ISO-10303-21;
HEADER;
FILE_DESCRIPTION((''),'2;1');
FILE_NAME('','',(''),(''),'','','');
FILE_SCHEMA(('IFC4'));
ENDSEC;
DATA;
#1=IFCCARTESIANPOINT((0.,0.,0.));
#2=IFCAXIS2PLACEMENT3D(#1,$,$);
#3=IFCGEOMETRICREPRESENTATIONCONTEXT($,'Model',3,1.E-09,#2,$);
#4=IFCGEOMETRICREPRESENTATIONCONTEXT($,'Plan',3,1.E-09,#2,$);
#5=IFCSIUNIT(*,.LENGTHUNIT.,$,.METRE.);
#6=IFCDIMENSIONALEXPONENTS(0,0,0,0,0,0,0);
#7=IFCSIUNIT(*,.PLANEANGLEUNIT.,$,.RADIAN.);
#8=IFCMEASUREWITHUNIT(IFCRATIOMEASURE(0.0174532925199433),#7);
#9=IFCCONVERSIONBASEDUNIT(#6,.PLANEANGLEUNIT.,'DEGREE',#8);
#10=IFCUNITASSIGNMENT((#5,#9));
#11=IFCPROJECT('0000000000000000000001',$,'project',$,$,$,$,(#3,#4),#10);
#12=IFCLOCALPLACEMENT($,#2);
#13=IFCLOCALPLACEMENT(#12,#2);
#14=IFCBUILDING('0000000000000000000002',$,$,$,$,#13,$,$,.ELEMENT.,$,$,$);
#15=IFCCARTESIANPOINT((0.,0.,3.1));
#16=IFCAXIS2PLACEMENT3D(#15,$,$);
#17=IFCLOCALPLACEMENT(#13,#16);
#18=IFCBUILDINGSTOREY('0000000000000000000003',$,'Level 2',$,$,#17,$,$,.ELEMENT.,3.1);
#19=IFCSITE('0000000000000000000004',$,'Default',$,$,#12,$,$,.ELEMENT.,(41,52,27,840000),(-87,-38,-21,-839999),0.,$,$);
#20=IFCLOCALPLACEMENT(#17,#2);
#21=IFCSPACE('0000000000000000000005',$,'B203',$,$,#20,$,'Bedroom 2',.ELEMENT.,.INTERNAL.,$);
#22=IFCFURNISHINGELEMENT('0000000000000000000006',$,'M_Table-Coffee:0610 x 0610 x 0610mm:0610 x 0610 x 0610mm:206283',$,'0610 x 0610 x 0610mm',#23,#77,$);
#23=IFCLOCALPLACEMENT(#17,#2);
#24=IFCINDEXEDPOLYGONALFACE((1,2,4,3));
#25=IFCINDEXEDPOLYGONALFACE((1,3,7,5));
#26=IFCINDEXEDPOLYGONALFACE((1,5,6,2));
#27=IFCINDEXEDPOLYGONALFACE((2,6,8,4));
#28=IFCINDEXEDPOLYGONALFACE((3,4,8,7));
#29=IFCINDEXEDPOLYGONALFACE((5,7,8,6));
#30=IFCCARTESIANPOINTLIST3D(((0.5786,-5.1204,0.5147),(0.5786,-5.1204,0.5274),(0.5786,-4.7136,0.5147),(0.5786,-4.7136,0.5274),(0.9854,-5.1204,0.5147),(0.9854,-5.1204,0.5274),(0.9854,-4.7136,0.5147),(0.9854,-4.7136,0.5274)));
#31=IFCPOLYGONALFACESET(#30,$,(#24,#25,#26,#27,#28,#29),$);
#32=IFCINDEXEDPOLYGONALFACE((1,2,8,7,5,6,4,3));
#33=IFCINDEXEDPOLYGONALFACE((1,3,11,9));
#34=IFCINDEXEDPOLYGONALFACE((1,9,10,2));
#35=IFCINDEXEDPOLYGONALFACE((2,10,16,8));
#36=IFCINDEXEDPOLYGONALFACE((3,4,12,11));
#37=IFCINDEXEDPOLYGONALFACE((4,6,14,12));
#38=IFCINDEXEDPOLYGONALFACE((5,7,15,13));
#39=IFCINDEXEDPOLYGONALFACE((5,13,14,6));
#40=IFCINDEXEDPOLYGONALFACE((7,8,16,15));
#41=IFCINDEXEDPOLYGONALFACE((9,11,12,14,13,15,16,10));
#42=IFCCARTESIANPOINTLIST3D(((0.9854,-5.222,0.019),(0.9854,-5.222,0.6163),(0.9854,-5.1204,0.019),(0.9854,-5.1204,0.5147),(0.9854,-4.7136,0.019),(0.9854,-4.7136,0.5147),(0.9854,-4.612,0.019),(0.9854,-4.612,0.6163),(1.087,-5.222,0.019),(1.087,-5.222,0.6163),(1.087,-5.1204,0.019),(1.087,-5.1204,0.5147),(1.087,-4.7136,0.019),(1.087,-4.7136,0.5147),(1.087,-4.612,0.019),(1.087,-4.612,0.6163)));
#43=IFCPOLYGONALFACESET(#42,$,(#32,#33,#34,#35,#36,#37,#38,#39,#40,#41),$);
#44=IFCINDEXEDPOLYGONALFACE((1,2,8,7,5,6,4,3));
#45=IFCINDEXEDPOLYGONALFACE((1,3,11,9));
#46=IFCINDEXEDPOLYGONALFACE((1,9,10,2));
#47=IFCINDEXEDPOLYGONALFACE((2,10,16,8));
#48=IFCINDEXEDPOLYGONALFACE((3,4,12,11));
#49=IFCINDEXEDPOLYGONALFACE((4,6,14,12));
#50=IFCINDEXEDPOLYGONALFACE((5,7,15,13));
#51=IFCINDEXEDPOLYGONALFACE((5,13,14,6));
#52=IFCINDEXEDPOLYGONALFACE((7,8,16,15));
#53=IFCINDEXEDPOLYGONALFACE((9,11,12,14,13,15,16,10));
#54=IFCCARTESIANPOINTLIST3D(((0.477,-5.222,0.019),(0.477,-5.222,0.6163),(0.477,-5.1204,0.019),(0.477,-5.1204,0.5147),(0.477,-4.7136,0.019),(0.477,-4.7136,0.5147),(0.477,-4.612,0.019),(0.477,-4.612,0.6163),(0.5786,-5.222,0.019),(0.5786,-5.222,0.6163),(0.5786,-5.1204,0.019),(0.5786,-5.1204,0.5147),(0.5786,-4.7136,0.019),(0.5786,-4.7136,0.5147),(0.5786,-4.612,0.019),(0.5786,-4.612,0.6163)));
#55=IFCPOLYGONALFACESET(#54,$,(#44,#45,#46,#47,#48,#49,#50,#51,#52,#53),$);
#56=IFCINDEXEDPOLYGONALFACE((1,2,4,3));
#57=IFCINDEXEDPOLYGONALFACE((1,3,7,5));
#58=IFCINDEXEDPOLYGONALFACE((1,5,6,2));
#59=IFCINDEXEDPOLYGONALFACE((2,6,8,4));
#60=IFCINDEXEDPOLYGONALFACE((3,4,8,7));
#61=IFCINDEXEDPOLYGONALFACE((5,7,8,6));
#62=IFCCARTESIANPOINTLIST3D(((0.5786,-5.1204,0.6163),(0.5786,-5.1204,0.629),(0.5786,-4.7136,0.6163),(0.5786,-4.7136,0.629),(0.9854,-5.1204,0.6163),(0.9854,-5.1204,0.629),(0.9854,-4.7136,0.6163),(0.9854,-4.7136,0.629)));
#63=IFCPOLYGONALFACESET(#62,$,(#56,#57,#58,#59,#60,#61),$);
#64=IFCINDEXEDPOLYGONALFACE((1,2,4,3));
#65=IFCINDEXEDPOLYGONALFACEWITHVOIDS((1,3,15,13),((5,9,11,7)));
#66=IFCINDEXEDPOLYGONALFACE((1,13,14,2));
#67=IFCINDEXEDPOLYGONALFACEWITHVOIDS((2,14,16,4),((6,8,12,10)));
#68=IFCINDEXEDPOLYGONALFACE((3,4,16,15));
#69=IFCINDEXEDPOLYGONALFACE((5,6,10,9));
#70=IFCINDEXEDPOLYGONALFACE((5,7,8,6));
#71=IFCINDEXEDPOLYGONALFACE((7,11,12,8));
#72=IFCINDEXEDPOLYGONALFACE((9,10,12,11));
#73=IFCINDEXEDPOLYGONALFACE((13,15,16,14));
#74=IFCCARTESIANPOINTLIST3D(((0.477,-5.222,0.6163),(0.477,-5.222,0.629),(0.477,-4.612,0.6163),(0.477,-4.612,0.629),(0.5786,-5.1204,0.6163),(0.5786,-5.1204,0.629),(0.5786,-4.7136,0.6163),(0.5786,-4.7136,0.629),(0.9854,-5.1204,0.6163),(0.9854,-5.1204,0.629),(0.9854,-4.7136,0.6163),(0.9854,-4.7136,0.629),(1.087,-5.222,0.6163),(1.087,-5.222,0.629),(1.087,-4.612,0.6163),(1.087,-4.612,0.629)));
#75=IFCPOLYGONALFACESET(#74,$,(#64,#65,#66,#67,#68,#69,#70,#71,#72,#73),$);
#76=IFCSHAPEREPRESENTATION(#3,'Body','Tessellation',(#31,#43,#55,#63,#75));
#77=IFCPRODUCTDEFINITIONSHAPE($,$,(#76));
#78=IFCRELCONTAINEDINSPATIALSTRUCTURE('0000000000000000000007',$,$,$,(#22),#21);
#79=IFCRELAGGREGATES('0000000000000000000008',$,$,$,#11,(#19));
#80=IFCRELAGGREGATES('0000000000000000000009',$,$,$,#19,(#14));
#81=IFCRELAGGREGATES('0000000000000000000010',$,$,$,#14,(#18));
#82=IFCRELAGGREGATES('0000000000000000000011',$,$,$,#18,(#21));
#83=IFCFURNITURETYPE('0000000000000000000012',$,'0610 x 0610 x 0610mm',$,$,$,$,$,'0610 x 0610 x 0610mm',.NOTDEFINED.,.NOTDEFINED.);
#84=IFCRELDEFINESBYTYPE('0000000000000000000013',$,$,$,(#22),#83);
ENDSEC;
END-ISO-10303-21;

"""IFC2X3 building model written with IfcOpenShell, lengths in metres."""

from ifc_helpers import new_model, entity, si_unit, converted_unit, frame, origin, origin_2d_with_axis, place, context, project, spatial, polyline, rectangle, outline, extrude, source, transform, mapped, type_object, type_shapes, element, save


model = new_model("IFC2X3")

# Units and contexts
model_context = context("Model", 3, precision=1e-09, world=origin())
plan_context = context("Plan", 3, precision=1e-09, world=origin())
ifc_project = project(units=[si_unit("LENGTHUNIT", "METRE"), converted_unit("PLANEANGLEUNIT", "DEGREE", entity("IfcRatioMeasure", 0.0174532925199433), si_unit("PLANEANGLEUNIT", "RADIAN"), dimensions=[0, 0, 0, 0, 0, 0, 0])], contexts=[model_context, plan_context])

# Site, building, storey
site_placement = place(None, origin())
site = spatial("IfcSite", under=ifc_project, at=site_placement, Name="Default", CompositionType="ELEMENT", RefLatitude=(41, 52, 27, 840000), RefLongitude=(-87, -38, -21, -839999), RefElevation=0.0)
building_placement = place(site_placement, origin())
building = spatial("IfcBuilding", under=site, at=building_placement, CompositionType="ELEMENT")
storey_placement = place(building_placement, frame((0.0, 0.0, 3.1)))
storey = spatial("IfcBuildingStorey", under=building, at=storey_placement, Name="Level 2", CompositionType="ELEMENT", Elevation=3.1)

# Shared definitions
furniture_type = type_object("IfcFurnitureType", Name="0610 x 0610 x 0610mm", ElementType="0610 x 0610 x 0610mm", AssemblyPlace="NOTDEFINED")
shared_shape_1 = source(origin(), model_context, "Body", "SweptSolid", [
    extrude(rectangle(XDim=0.4068, YDim=0.4068, at=origin_2d_with_axis()), frame((0.0183, 0.0952, 0.4957), z_axis=(0.0, 0.0, 1.0), x_axis=(-1.0, 0.0, 0.0)), (0.0, 0.0, 1.0), 0.0127),
    extrude(outline(polyline([(-0.2732, -0.305), (0.324, -0.305), (0.324, 0.305), (-0.2732, 0.305), (-0.2732, 0.2034), (0.2225, 0.2034), (0.2225, -0.2034), (-0.2732, -0.2034), (-0.2732, -0.305)])), frame((0.2217, 0.0952, 0.2732), z_axis=(1.0, 0.0, 0.0), x_axis=(0.0, 0.0, 1.0)), (0.0, 0.0, 1.0), 0.1016),
    extrude(outline(polyline([(-0.305, -0.3241), (0.305, -0.3241), (0.305, 0.2733), (0.2034, 0.2733), (0.2034, -0.2224), (-0.2034, -0.2224), (-0.2034, 0.2733), (-0.305, 0.2733), (-0.305, -0.3241)])), frame((-0.2867, 0.0952, 0.2733), z_axis=(1.0, 0.0, 0.0), x_axis=(0.0, -1.0, 0.0)), (0.0, 0.0, 1.0), 0.1016),
    extrude(rectangle(XDim=0.4068, YDim=0.4068, at=origin_2d_with_axis()), frame((0.0183, 0.0952, 0.5973), z_axis=(0.0, 0.0, 1.0), x_axis=(-1.0, 0.0, 0.0)), (0.0, 0.0, 1.0), 0.0127),
    extrude(outline(polyline([(-0.305, -0.305), (0.305, -0.305), (0.305, 0.305), (-0.305, 0.305), (-0.305, -0.305)]), holes=[polyline([(-0.2034, -0.2034), (-0.2034, 0.2034), (0.2034, 0.2034), (0.2034, -0.2034), (-0.2034, -0.2034)])]), frame((0.0183, 0.0952, 0.5973), z_axis=(0.0, 0.0, 1.0), x_axis=(-1.0, 0.0, 0.0)), (0.0, 0.0, 1.0), 0.0127),
])
type_shapes(furniture_type, [shared_shape_1])

# Shared definitions
space_1_placement = place(storey_placement, origin())
space_1 = spatial("IfcSpace", under=storey, at=space_1_placement, Name="B203", LongName="Bedroom 2", CompositionType="ELEMENT", InteriorOrExteriorSpace="INTERNAL")

# Furnishing element
furnishing_1_placement = place(space_1_placement, frame((0.7637, -5.0122, 0.019)))
element("IfcFurnishingElement", 1, at=furnishing_1_placement, inside=space_1, type_object=furniture_type, Name="M_Table-Coffee:0610 x 0610 x 0610mm:0610 x 0610 x 0610mm:206283", ObjectType="0610 x 0610 x 0610mm", context=model_context, shape_type="MappedRepresentation", body=[
    mapped(shared_shape_1, transform((0.0, 0.0, 0.0), scale=1.0)),
])

save(model, "model.ifc")
